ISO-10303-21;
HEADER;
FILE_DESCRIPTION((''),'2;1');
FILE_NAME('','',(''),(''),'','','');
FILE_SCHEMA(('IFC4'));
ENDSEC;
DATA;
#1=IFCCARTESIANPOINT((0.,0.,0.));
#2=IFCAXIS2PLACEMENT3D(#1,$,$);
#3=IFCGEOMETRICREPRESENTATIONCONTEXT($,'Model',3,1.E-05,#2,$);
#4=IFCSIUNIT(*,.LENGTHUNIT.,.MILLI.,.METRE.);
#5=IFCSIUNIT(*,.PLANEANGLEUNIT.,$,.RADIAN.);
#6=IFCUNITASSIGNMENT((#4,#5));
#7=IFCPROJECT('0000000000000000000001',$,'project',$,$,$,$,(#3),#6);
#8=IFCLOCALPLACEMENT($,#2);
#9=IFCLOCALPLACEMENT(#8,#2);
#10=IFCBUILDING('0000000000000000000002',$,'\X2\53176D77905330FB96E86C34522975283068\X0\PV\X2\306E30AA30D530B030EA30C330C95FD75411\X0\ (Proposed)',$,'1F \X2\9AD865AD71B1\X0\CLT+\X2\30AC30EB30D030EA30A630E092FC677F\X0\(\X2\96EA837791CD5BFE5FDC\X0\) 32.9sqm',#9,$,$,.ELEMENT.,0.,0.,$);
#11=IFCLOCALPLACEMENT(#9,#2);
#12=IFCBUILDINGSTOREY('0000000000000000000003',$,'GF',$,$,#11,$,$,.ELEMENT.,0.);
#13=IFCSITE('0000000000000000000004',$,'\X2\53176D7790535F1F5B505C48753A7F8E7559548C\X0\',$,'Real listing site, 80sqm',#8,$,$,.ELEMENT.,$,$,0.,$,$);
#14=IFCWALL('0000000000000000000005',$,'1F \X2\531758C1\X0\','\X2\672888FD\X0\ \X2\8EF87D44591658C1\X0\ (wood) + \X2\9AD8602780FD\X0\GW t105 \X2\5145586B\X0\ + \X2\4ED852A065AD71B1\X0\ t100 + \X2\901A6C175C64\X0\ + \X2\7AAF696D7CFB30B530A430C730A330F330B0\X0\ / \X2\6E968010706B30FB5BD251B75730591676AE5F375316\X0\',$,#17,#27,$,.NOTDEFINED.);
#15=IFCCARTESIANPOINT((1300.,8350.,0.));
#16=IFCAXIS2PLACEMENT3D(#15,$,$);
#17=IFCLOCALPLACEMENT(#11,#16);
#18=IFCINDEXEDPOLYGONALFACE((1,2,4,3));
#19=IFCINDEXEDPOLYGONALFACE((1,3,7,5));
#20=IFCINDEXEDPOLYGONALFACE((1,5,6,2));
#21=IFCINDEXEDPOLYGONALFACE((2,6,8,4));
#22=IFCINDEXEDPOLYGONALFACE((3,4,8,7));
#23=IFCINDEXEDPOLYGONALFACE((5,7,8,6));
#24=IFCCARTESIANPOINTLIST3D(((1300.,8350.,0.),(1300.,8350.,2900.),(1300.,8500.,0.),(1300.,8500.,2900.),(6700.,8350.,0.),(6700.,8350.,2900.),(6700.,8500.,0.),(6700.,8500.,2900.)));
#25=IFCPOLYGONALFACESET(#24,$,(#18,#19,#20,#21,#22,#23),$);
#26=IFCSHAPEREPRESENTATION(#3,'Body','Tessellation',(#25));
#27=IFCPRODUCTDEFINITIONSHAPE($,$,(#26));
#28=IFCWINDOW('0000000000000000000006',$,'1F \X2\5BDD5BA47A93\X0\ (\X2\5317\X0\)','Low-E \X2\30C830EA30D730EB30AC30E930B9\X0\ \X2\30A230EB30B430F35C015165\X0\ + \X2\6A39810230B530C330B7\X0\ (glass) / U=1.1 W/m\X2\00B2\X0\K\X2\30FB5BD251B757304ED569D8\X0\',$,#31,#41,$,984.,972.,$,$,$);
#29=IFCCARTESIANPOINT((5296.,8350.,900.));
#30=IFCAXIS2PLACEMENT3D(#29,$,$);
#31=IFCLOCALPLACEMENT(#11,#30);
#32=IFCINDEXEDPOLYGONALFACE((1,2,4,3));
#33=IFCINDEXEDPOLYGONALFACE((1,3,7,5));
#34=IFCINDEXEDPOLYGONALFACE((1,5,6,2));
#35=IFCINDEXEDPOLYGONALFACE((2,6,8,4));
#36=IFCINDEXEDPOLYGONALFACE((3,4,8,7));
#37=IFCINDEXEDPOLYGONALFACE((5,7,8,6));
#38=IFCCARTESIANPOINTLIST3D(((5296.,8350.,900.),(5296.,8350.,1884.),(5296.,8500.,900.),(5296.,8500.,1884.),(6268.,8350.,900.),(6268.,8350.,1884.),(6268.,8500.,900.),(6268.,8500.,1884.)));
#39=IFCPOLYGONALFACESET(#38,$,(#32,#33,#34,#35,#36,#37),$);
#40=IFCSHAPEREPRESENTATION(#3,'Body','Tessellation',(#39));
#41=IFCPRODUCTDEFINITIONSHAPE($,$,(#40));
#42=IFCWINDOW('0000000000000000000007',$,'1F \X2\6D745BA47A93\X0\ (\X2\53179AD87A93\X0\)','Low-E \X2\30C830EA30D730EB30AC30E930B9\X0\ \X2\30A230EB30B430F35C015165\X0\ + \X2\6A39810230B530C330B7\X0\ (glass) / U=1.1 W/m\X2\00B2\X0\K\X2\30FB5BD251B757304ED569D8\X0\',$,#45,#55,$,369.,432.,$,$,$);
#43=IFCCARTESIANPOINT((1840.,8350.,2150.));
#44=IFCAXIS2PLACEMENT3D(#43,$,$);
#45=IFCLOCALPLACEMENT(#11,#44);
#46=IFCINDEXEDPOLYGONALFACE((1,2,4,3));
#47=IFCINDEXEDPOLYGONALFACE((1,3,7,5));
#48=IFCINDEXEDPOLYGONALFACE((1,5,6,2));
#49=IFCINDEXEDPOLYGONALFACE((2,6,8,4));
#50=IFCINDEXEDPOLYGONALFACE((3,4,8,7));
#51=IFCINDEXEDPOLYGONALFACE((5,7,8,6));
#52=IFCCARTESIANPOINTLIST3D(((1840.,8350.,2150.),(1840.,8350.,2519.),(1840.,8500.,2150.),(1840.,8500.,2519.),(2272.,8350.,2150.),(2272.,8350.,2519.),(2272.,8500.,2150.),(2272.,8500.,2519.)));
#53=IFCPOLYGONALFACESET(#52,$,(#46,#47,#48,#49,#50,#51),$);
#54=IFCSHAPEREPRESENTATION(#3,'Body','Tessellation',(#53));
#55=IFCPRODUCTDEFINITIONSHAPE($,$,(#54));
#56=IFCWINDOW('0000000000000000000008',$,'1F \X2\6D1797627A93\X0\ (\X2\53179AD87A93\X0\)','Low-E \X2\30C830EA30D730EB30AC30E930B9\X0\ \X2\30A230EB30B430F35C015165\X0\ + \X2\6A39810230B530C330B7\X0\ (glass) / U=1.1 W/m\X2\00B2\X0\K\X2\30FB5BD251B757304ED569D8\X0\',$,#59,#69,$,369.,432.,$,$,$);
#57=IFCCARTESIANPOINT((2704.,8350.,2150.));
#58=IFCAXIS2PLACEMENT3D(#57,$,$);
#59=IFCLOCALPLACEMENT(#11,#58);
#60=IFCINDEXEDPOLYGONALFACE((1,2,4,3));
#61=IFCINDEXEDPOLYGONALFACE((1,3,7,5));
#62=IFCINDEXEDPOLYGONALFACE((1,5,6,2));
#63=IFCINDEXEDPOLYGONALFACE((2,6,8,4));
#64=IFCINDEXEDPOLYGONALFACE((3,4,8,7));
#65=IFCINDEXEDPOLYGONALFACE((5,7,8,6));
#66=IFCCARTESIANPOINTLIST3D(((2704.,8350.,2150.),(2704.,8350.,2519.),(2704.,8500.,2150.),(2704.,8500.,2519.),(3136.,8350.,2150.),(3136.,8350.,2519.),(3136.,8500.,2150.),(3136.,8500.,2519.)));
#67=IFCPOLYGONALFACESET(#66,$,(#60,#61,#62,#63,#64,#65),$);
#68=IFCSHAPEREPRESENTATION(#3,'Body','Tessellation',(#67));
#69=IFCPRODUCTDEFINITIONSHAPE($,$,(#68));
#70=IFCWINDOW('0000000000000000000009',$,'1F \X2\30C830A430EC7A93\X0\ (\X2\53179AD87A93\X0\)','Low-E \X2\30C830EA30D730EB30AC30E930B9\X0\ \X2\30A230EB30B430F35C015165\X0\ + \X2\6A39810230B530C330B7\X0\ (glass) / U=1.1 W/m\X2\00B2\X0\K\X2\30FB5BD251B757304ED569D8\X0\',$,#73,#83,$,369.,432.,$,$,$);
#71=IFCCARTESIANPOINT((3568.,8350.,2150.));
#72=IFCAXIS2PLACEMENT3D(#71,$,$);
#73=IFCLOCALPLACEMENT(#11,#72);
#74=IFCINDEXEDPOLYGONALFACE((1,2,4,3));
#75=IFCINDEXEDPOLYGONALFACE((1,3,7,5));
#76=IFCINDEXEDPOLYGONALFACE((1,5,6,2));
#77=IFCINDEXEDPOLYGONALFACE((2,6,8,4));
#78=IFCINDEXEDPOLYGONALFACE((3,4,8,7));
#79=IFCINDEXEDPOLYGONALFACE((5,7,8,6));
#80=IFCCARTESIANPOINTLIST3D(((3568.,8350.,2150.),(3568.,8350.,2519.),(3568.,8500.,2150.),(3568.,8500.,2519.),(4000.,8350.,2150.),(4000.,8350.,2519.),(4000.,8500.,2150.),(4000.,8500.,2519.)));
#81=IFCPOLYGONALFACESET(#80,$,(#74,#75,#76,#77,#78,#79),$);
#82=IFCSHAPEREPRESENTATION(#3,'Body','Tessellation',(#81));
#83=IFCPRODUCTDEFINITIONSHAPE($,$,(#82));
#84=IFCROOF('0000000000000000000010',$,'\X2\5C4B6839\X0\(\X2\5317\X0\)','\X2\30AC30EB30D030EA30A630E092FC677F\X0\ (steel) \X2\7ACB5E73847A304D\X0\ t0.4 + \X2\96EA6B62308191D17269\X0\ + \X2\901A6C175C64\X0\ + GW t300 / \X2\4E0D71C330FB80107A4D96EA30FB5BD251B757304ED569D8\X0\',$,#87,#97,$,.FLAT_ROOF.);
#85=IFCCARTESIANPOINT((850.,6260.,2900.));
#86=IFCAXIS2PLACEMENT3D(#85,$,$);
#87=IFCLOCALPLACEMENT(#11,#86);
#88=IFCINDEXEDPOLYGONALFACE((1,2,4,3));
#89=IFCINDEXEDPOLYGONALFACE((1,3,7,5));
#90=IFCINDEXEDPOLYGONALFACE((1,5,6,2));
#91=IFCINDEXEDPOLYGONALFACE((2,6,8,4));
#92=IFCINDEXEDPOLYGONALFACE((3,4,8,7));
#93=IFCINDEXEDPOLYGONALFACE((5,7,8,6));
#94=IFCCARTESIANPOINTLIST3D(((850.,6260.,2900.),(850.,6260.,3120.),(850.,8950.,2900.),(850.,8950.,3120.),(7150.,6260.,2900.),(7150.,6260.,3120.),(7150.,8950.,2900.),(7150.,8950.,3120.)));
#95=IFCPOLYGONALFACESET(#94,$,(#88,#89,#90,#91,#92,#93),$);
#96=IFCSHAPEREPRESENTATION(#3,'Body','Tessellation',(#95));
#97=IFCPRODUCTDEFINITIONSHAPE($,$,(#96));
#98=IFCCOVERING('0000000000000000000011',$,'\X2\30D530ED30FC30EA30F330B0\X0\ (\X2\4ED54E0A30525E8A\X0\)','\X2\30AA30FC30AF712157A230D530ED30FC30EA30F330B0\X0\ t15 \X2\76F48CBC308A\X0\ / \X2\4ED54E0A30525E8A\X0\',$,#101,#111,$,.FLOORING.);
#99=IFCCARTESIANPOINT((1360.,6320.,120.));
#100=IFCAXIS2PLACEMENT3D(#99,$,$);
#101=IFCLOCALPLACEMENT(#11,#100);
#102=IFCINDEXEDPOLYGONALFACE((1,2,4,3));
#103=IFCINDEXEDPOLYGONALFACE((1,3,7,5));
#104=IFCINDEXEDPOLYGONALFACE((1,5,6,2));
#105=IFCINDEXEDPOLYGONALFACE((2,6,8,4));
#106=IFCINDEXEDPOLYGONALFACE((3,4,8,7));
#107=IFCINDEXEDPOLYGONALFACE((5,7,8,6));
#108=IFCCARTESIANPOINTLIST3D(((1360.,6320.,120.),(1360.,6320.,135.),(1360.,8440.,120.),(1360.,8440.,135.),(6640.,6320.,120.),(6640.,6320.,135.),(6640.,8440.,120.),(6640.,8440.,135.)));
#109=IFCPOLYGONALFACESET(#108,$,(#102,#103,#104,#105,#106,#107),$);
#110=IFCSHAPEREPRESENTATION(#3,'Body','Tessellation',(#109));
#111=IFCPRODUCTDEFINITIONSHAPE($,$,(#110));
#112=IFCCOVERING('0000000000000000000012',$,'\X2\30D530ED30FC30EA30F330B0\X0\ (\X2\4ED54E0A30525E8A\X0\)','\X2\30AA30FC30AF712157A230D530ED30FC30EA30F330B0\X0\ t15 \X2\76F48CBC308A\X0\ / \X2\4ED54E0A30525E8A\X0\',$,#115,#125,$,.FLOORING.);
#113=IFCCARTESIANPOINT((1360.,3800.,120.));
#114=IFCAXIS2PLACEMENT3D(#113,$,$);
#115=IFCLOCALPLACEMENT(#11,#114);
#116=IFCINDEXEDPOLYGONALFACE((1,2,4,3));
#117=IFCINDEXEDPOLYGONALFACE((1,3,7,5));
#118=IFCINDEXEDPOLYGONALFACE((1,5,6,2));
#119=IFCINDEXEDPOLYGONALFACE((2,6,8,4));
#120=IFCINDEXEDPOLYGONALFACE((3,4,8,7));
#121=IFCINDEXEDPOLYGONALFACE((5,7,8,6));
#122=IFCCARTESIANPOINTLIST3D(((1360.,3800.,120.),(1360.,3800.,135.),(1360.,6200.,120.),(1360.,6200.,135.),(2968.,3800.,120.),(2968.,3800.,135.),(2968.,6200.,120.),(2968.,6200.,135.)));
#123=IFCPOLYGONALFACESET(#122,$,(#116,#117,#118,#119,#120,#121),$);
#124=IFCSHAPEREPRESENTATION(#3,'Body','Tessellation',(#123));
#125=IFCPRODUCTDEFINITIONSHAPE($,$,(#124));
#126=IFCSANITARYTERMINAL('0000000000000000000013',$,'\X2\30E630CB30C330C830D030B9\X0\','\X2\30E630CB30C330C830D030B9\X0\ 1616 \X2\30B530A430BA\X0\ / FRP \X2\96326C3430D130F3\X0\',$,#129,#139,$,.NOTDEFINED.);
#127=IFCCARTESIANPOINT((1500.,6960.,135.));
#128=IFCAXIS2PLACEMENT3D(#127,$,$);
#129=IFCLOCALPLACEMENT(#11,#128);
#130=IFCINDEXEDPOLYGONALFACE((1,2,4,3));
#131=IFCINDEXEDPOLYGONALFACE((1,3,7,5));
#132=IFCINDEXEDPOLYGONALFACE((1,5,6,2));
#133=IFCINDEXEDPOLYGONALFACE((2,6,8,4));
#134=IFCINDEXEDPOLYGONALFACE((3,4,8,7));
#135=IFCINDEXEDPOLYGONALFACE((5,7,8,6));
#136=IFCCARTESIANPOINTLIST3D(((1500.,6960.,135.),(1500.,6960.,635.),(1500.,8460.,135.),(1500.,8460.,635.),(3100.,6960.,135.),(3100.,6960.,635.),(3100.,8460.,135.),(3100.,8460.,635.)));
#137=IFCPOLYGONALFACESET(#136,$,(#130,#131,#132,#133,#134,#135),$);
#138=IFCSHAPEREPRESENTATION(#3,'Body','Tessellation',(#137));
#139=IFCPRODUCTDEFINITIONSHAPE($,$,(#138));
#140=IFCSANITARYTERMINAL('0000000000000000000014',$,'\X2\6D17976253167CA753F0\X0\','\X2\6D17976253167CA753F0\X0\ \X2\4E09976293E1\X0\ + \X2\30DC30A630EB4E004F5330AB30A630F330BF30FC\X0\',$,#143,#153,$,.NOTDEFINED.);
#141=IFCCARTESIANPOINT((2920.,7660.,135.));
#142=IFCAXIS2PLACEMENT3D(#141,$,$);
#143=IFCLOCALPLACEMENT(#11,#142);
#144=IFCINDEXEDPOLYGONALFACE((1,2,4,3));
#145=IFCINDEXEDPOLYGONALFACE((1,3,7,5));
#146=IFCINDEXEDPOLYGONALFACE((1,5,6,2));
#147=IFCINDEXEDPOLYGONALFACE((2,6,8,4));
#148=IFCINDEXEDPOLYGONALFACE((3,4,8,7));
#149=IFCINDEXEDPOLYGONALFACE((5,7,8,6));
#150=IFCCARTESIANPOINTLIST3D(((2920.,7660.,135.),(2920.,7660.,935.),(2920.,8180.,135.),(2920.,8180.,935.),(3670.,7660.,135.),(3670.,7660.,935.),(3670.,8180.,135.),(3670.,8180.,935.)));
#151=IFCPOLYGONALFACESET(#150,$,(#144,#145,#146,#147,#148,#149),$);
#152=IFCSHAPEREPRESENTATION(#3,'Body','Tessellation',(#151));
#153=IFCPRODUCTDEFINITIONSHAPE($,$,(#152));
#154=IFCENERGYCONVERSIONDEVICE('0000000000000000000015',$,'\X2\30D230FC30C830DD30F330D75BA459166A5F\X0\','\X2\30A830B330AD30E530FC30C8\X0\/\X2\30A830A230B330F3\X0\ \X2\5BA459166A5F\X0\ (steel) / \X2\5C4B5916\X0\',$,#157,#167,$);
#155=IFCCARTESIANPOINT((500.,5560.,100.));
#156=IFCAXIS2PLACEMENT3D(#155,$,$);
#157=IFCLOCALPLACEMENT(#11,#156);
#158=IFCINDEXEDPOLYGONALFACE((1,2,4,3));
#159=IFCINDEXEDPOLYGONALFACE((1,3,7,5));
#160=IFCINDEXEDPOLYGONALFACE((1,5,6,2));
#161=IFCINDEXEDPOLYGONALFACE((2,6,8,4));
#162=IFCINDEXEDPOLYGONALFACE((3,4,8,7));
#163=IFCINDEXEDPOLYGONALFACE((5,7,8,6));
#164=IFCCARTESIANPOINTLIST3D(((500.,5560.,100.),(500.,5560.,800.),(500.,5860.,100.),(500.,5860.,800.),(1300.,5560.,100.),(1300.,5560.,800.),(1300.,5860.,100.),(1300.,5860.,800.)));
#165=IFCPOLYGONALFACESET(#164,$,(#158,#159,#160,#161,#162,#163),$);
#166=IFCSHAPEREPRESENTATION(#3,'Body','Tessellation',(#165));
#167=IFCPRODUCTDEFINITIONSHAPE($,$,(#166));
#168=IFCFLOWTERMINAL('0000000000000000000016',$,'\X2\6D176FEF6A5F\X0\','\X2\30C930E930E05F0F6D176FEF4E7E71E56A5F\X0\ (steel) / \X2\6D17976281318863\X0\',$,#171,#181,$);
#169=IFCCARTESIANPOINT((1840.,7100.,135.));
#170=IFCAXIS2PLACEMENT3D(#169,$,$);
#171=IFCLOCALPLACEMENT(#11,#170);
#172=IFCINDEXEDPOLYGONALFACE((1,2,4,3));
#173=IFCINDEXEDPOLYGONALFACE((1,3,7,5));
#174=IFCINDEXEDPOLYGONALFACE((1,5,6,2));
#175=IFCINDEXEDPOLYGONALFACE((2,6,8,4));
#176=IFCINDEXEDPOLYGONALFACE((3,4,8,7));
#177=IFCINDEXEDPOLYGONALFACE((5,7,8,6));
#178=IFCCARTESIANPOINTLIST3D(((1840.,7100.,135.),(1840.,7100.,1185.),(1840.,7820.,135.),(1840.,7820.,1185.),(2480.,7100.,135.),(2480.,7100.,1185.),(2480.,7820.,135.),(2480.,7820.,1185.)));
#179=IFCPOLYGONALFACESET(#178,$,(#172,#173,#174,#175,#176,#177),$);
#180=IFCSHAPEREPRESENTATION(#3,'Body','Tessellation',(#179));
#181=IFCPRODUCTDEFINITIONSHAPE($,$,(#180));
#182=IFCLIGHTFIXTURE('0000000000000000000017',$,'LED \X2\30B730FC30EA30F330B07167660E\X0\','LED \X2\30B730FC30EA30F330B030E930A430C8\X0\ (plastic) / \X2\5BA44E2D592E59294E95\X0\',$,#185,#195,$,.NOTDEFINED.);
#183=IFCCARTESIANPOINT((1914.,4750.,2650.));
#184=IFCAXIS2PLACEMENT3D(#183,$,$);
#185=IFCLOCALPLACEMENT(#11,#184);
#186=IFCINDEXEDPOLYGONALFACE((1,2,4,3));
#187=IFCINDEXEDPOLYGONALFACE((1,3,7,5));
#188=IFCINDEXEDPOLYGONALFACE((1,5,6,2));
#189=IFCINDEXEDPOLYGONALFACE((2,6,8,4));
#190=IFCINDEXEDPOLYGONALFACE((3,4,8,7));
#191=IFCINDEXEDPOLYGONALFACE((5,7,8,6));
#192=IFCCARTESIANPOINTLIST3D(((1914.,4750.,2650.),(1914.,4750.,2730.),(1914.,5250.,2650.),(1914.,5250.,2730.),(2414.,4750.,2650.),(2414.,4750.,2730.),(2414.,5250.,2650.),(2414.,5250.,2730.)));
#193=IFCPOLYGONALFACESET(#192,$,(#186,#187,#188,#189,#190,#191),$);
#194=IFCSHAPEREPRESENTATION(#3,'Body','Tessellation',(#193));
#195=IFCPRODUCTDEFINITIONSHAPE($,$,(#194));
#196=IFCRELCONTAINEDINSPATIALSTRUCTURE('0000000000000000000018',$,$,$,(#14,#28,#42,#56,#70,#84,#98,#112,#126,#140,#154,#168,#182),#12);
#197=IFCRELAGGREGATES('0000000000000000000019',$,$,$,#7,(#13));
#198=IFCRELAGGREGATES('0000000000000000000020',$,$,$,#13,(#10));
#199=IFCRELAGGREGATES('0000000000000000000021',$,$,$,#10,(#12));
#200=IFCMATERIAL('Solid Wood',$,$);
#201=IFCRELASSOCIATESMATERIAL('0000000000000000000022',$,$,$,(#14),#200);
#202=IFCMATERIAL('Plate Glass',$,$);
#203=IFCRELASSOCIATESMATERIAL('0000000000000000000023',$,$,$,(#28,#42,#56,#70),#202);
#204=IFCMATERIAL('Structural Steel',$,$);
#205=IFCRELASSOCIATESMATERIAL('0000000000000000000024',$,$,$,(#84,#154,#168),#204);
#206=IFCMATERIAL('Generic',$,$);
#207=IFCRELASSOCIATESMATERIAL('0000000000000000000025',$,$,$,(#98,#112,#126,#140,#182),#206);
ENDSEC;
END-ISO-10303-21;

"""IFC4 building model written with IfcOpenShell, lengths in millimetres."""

from ifc_helpers import new_model, si_unit, frame, frame_2d, origin, place, context, project, spatial, rectangle, extrude, material, element, fill, save


model = new_model("IFC4")

# Units and contexts
model_context = context("Model", 3, precision=1e-05, world=origin())
ifc_project = project(units=[si_unit("LENGTHUNIT", "METRE", prefix="MILLI"), si_unit("PLANEANGLEUNIT", "RADIAN")], contexts=[model_context])

# Site, building, storey
site_placement = place(None, origin())
site = spatial("IfcSite", under=ifc_project, at=site_placement, Name="北海道弟子屈町美留和", ObjectType="Real listing site, 80sqm", CompositionType="ELEMENT", RefElevation=0.0)
building_placement = place(site_placement, origin())
building = spatial("IfcBuilding", under=site, at=building_placement, Name="北海道・雨水利用とPVのオフグリッド志向 (Proposed)", ObjectType="1F 高断熱CLT+ガルバリウム鋼板(雪荷重対応) 32.9sqm", CompositionType="ELEMENT", ElevationOfRefHeight=0.0, ElevationOfTerrain=0.0)
storey_placement = place(building_placement, origin())
storey = spatial("IfcBuildingStorey", under=building, at=storey_placement, Name="GF", CompositionType="ELEMENT", Elevation=0.0)

# Shared definitions
ifc_material_1 = material(Name="Solid Wood")

# Wall, openings, windows
wall_1_placement = place(storey_placement, frame((1300.0, 8350.0, 0.0)))
wall_1 = element("IfcWall", 1, at=wall_1_placement, inside=storey, material=ifc_material_1, Name="1F 北壁", Description="木製 軸組外壁 (wood) + 高性能GW t105 充填 + 付加断熱 t100 + 通気層 + 窯業系サイディング / 準耐火・寒冷地外皮強化", PredefinedType="NOTDEFINED", context=model_context, shape_type="SweptSolid", body=[
    extrude(rectangle(XDim=5400.0, YDim=150.0, at=frame_2d((2700.0, 75.0))), frame((1300.0, 8350.0, 0.0)), (0.0, 0.0, 1.0), 2900.0),
])
opening_1_placement = place(storey_placement, frame((5296.0, 8350.0, 900.0)))
opening_1 = element("IfcOpeningElement", 2, at=opening_1_placement, cuts=wall_1, PredefinedType="NOTDEFINED", context=model_context, shape_type="SweptSolid", body=[
    extrude(rectangle(XDim=972.0, YDim=150.0, at=frame_2d((486.0, 75.0))), frame((5296.0, 8350.0, 900.0)), (0.0, 0.0, 1.0), 984.0),
])
opening_2_placement = place(storey_placement, frame((1840.0, 8350.0, 2150.0)))
opening_2 = element("IfcOpeningElement", 3, at=opening_2_placement, cuts=wall_1, PredefinedType="NOTDEFINED", context=model_context, shape_type="SweptSolid", body=[
    extrude(rectangle(XDim=432.0, YDim=150.0, at=frame_2d((216.0, 75.0))), frame((1840.0, 8350.0, 2150.0)), (0.0, 0.0, 1.0), 369.0),
])
opening_3_placement = place(storey_placement, frame((2704.0, 8350.0, 2150.0)))
opening_3 = element("IfcOpeningElement", 4, at=opening_3_placement, cuts=wall_1, PredefinedType="NOTDEFINED", context=model_context, shape_type="SweptSolid", body=[
    extrude(rectangle(XDim=432.0, YDim=150.0, at=frame_2d((216.0, 75.0))), frame((2704.0, 8350.0, 2150.0)), (0.0, 0.0, 1.0), 369.0),
])
opening_4_placement = place(storey_placement, frame((3568.0, 8350.0, 2150.0)))
opening_4 = element("IfcOpeningElement", 5, at=opening_4_placement, cuts=wall_1, PredefinedType="NOTDEFINED", context=model_context, shape_type="SweptSolid", body=[
    extrude(rectangle(XDim=432.0, YDim=150.0, at=frame_2d((216.0, 75.0))), frame((3568.0, 8350.0, 2150.0)), (0.0, 0.0, 1.0), 369.0),
])
ifc_material_2 = material(Name="Plate Glass")
window_1_placement = place(storey_placement, frame((5296.0, 8350.0, 900.0)))
window_1 = element("IfcWindow", 6, at=window_1_placement, inside=storey, material=ifc_material_2, Name="1F 寝室窓 (北)", Description="Low-E トリプルガラス アルゴン封入 + 樹脂サッシ (glass) / U=1.1 W/m²K・寒冷地仕様", OverallHeight=984.0, OverallWidth=972.0, context=model_context, shape_type="SweptSolid", body=[
    extrude(rectangle(XDim=972.0, YDim=150.0, at=frame_2d((486.0, 75.0))), frame((5296.0, 8350.0, 900.0)), (0.0, 0.0, 1.0), 984.0),
])
fill(opening_1, window_1)
window_2_placement = place(storey_placement, frame((1840.0, 8350.0, 2150.0)))
window_2 = element("IfcWindow", 7, at=window_2_placement, inside=storey, material=ifc_material_2, Name="1F 浴室窓 (北高窓)", Description="Low-E トリプルガラス アルゴン封入 + 樹脂サッシ (glass) / U=1.1 W/m²K・寒冷地仕様", OverallHeight=369.0, OverallWidth=432.0, context=model_context, shape_type="SweptSolid", body=[
    extrude(rectangle(XDim=432.0, YDim=150.0, at=frame_2d((216.0, 75.0))), frame((1840.0, 8350.0, 2150.0)), (0.0, 0.0, 1.0), 369.0),
])
fill(opening_2, window_2)
window_3_placement = place(storey_placement, frame((2704.0, 8350.0, 2150.0)))
window_3 = element("IfcWindow", 8, at=window_3_placement, inside=storey, material=ifc_material_2, Name="1F 洗面窓 (北高窓)", Description="Low-E トリプルガラス アルゴン封入 + 樹脂サッシ (glass) / U=1.1 W/m²K・寒冷地仕様", OverallHeight=369.0, OverallWidth=432.0, context=model_context, shape_type="SweptSolid", body=[
    extrude(rectangle(XDim=432.0, YDim=150.0, at=frame_2d((216.0, 75.0))), frame((2704.0, 8350.0, 2150.0)), (0.0, 0.0, 1.0), 369.0),
])
fill(opening_3, window_3)
window_4_placement = place(storey_placement, frame((3568.0, 8350.0, 2150.0)))
window_4 = element("IfcWindow", 9, at=window_4_placement, inside=storey, material=ifc_material_2, Name="1F トイレ窓 (北高窓)", Description="Low-E トリプルガラス アルゴン封入 + 樹脂サッシ (glass) / U=1.1 W/m²K・寒冷地仕様", OverallHeight=369.0, OverallWidth=432.0, context=model_context, shape_type="SweptSolid", body=[
    extrude(rectangle(XDim=432.0, YDim=150.0, at=frame_2d((216.0, 75.0))), frame((3568.0, 8350.0, 2150.0)), (0.0, 0.0, 1.0), 369.0),
])
fill(opening_4, window_4)

# Roof
ifc_material_3 = material(Name="Structural Steel")
roof_placement = place(storey_placement, frame((850.0, 6260.0, 2900.0)))
element("IfcRoof", 10, at=roof_placement, inside=storey, material=ifc_material_3, Name="屋根(北)", Description="ガルバリウム鋼板 (steel) 立平葺き t0.4 + 雪止め金物 + 通気層 + GW t300 / 不燃・耐積雪・寒冷地仕様", PredefinedType="FLAT_ROOF", context=model_context, shape_type="SweptSolid", body=[
    extrude(rectangle(XDim=6300.0, YDim=2690.0, at=frame_2d((3150.0, 1345.0))), frame((850.0, 6260.0, 2900.0)), (0.0, 0.0, 1.0), 220.0),
])

# Coverings
ifc_material_4 = material(Name="Generic")
covering_1_placement = place(storey_placement, frame((1360.0, 6320.0, 120.0)))
element("IfcCovering", 11, at=covering_1_placement, inside=storey, material=ifc_material_4, Name="フローリング (仕上げ床)", Description="オーク無垢フローリング t15 直貼り / 仕上げ床", PredefinedType="FLOORING", context=model_context, shape_type="SweptSolid", body=[
    extrude(rectangle(XDim=5280.0, YDim=2120.0, at=frame_2d((2640.0, 1060.0))), frame((1360.0, 6320.0, 120.0)), (0.0, 0.0, 1.0), 15.0),
])
covering_2_placement = place(storey_placement, frame((1360.0, 3800.0, 120.0)))
element("IfcCovering", 12, at=covering_2_placement, inside=storey, material=ifc_material_4, Name="フローリング (仕上げ床)", Description="オーク無垢フローリング t15 直貼り / 仕上げ床", PredefinedType="FLOORING", context=model_context, shape_type="SweptSolid", body=[
    extrude(rectangle(XDim=1608.0, YDim=2400.0, at=frame_2d((804.0, 1200.0))), frame((1360.0, 3800.0, 120.0)), (0.0, 0.0, 1.0), 15.0),
])

# Sanitary terminals
sanitary_terminal_1_placement = place(storey_placement, frame((1500.0, 6960.0, 135.0)))
element("IfcSanitaryTerminal", 13, at=sanitary_terminal_1_placement, inside=storey, material=ifc_material_4, Name="ユニットバス", Description="ユニットバス 1616 サイズ / FRP 防水パン", PredefinedType="NOTDEFINED", context=model_context, shape_type="SweptSolid", body=[
    extrude(rectangle(XDim=1600.0, YDim=1500.0, at=frame_2d((800.0, 750.0))), frame((1500.0, 6960.0, 135.0)), (0.0, 0.0, 1.0), 500.0),
])
sanitary_terminal_2_placement = place(storey_placement, frame((2920.0, 7660.0, 135.0)))
element("IfcSanitaryTerminal", 14, at=sanitary_terminal_2_placement, inside=storey, material=ifc_material_4, Name="洗面化粧台", Description="洗面化粧台 三面鏡 + ボウル一体カウンター", PredefinedType="NOTDEFINED", context=model_context, shape_type="SweptSolid", body=[
    extrude(rectangle(XDim=750.0, YDim=520.0, at=frame_2d((375.0, 260.0))), frame((2920.0, 7660.0, 135.0)), (0.0, 0.0, 1.0), 800.0),
])

# Energy conversion device
energy_conversion_device_placement = place(storey_placement, frame((500.0, 5560.0, 100.0)))
element("IfcEnergyConversionDevice", 15, at=energy_conversion_device_placement, inside=storey, material=ifc_material_3, Name="ヒートポンプ室外機", Description="エコキュート/エアコン 室外機 (steel) / 屋外", context=model_context, shape_type="SweptSolid", body=[
    extrude(rectangle(XDim=800.0, YDim=300.0, at=frame_2d((400.0, 150.0))), frame((500.0, 5560.0, 100.0)), (0.0, 0.0, 1.0), 700.0),
])

# Flow terminal
flow_terminal_placement = place(storey_placement, frame((1840.0, 7100.0, 135.0)))
element("IfcFlowTerminal", 16, at=flow_terminal_placement, inside=storey, material=ifc_material_3, Name="洗濯機", Description="ドラム式洗濯乾燥機 (steel) / 洗面脱衣", context=model_context, shape_type="SweptSolid", body=[
    extrude(rectangle(XDim=640.0, YDim=720.0, at=frame_2d((320.0, 360.0))), frame((1840.0, 7100.0, 135.0)), (0.0, 0.0, 1.0), 1050.0),
])

# Light fixture
light_fixture_placement = place(storey_placement, frame((1914.0, 4750.0, 2650.0)))
element("IfcLightFixture", 17, at=light_fixture_placement, inside=storey, material=ifc_material_4, Name="LED シーリング照明", Description="LED シーリングライト (plastic) / 室中央天井", PredefinedType="NOTDEFINED", context=model_context, shape_type="SweptSolid", body=[
    extrude(rectangle(XDim=500.0, YDim=500.0, at=frame_2d((250.0, 250.0))), frame((1914.0, 4750.0, 2650.0)), (0.0, 0.0, 1.0), 80.0),
])

save(model, "model.ifc")
